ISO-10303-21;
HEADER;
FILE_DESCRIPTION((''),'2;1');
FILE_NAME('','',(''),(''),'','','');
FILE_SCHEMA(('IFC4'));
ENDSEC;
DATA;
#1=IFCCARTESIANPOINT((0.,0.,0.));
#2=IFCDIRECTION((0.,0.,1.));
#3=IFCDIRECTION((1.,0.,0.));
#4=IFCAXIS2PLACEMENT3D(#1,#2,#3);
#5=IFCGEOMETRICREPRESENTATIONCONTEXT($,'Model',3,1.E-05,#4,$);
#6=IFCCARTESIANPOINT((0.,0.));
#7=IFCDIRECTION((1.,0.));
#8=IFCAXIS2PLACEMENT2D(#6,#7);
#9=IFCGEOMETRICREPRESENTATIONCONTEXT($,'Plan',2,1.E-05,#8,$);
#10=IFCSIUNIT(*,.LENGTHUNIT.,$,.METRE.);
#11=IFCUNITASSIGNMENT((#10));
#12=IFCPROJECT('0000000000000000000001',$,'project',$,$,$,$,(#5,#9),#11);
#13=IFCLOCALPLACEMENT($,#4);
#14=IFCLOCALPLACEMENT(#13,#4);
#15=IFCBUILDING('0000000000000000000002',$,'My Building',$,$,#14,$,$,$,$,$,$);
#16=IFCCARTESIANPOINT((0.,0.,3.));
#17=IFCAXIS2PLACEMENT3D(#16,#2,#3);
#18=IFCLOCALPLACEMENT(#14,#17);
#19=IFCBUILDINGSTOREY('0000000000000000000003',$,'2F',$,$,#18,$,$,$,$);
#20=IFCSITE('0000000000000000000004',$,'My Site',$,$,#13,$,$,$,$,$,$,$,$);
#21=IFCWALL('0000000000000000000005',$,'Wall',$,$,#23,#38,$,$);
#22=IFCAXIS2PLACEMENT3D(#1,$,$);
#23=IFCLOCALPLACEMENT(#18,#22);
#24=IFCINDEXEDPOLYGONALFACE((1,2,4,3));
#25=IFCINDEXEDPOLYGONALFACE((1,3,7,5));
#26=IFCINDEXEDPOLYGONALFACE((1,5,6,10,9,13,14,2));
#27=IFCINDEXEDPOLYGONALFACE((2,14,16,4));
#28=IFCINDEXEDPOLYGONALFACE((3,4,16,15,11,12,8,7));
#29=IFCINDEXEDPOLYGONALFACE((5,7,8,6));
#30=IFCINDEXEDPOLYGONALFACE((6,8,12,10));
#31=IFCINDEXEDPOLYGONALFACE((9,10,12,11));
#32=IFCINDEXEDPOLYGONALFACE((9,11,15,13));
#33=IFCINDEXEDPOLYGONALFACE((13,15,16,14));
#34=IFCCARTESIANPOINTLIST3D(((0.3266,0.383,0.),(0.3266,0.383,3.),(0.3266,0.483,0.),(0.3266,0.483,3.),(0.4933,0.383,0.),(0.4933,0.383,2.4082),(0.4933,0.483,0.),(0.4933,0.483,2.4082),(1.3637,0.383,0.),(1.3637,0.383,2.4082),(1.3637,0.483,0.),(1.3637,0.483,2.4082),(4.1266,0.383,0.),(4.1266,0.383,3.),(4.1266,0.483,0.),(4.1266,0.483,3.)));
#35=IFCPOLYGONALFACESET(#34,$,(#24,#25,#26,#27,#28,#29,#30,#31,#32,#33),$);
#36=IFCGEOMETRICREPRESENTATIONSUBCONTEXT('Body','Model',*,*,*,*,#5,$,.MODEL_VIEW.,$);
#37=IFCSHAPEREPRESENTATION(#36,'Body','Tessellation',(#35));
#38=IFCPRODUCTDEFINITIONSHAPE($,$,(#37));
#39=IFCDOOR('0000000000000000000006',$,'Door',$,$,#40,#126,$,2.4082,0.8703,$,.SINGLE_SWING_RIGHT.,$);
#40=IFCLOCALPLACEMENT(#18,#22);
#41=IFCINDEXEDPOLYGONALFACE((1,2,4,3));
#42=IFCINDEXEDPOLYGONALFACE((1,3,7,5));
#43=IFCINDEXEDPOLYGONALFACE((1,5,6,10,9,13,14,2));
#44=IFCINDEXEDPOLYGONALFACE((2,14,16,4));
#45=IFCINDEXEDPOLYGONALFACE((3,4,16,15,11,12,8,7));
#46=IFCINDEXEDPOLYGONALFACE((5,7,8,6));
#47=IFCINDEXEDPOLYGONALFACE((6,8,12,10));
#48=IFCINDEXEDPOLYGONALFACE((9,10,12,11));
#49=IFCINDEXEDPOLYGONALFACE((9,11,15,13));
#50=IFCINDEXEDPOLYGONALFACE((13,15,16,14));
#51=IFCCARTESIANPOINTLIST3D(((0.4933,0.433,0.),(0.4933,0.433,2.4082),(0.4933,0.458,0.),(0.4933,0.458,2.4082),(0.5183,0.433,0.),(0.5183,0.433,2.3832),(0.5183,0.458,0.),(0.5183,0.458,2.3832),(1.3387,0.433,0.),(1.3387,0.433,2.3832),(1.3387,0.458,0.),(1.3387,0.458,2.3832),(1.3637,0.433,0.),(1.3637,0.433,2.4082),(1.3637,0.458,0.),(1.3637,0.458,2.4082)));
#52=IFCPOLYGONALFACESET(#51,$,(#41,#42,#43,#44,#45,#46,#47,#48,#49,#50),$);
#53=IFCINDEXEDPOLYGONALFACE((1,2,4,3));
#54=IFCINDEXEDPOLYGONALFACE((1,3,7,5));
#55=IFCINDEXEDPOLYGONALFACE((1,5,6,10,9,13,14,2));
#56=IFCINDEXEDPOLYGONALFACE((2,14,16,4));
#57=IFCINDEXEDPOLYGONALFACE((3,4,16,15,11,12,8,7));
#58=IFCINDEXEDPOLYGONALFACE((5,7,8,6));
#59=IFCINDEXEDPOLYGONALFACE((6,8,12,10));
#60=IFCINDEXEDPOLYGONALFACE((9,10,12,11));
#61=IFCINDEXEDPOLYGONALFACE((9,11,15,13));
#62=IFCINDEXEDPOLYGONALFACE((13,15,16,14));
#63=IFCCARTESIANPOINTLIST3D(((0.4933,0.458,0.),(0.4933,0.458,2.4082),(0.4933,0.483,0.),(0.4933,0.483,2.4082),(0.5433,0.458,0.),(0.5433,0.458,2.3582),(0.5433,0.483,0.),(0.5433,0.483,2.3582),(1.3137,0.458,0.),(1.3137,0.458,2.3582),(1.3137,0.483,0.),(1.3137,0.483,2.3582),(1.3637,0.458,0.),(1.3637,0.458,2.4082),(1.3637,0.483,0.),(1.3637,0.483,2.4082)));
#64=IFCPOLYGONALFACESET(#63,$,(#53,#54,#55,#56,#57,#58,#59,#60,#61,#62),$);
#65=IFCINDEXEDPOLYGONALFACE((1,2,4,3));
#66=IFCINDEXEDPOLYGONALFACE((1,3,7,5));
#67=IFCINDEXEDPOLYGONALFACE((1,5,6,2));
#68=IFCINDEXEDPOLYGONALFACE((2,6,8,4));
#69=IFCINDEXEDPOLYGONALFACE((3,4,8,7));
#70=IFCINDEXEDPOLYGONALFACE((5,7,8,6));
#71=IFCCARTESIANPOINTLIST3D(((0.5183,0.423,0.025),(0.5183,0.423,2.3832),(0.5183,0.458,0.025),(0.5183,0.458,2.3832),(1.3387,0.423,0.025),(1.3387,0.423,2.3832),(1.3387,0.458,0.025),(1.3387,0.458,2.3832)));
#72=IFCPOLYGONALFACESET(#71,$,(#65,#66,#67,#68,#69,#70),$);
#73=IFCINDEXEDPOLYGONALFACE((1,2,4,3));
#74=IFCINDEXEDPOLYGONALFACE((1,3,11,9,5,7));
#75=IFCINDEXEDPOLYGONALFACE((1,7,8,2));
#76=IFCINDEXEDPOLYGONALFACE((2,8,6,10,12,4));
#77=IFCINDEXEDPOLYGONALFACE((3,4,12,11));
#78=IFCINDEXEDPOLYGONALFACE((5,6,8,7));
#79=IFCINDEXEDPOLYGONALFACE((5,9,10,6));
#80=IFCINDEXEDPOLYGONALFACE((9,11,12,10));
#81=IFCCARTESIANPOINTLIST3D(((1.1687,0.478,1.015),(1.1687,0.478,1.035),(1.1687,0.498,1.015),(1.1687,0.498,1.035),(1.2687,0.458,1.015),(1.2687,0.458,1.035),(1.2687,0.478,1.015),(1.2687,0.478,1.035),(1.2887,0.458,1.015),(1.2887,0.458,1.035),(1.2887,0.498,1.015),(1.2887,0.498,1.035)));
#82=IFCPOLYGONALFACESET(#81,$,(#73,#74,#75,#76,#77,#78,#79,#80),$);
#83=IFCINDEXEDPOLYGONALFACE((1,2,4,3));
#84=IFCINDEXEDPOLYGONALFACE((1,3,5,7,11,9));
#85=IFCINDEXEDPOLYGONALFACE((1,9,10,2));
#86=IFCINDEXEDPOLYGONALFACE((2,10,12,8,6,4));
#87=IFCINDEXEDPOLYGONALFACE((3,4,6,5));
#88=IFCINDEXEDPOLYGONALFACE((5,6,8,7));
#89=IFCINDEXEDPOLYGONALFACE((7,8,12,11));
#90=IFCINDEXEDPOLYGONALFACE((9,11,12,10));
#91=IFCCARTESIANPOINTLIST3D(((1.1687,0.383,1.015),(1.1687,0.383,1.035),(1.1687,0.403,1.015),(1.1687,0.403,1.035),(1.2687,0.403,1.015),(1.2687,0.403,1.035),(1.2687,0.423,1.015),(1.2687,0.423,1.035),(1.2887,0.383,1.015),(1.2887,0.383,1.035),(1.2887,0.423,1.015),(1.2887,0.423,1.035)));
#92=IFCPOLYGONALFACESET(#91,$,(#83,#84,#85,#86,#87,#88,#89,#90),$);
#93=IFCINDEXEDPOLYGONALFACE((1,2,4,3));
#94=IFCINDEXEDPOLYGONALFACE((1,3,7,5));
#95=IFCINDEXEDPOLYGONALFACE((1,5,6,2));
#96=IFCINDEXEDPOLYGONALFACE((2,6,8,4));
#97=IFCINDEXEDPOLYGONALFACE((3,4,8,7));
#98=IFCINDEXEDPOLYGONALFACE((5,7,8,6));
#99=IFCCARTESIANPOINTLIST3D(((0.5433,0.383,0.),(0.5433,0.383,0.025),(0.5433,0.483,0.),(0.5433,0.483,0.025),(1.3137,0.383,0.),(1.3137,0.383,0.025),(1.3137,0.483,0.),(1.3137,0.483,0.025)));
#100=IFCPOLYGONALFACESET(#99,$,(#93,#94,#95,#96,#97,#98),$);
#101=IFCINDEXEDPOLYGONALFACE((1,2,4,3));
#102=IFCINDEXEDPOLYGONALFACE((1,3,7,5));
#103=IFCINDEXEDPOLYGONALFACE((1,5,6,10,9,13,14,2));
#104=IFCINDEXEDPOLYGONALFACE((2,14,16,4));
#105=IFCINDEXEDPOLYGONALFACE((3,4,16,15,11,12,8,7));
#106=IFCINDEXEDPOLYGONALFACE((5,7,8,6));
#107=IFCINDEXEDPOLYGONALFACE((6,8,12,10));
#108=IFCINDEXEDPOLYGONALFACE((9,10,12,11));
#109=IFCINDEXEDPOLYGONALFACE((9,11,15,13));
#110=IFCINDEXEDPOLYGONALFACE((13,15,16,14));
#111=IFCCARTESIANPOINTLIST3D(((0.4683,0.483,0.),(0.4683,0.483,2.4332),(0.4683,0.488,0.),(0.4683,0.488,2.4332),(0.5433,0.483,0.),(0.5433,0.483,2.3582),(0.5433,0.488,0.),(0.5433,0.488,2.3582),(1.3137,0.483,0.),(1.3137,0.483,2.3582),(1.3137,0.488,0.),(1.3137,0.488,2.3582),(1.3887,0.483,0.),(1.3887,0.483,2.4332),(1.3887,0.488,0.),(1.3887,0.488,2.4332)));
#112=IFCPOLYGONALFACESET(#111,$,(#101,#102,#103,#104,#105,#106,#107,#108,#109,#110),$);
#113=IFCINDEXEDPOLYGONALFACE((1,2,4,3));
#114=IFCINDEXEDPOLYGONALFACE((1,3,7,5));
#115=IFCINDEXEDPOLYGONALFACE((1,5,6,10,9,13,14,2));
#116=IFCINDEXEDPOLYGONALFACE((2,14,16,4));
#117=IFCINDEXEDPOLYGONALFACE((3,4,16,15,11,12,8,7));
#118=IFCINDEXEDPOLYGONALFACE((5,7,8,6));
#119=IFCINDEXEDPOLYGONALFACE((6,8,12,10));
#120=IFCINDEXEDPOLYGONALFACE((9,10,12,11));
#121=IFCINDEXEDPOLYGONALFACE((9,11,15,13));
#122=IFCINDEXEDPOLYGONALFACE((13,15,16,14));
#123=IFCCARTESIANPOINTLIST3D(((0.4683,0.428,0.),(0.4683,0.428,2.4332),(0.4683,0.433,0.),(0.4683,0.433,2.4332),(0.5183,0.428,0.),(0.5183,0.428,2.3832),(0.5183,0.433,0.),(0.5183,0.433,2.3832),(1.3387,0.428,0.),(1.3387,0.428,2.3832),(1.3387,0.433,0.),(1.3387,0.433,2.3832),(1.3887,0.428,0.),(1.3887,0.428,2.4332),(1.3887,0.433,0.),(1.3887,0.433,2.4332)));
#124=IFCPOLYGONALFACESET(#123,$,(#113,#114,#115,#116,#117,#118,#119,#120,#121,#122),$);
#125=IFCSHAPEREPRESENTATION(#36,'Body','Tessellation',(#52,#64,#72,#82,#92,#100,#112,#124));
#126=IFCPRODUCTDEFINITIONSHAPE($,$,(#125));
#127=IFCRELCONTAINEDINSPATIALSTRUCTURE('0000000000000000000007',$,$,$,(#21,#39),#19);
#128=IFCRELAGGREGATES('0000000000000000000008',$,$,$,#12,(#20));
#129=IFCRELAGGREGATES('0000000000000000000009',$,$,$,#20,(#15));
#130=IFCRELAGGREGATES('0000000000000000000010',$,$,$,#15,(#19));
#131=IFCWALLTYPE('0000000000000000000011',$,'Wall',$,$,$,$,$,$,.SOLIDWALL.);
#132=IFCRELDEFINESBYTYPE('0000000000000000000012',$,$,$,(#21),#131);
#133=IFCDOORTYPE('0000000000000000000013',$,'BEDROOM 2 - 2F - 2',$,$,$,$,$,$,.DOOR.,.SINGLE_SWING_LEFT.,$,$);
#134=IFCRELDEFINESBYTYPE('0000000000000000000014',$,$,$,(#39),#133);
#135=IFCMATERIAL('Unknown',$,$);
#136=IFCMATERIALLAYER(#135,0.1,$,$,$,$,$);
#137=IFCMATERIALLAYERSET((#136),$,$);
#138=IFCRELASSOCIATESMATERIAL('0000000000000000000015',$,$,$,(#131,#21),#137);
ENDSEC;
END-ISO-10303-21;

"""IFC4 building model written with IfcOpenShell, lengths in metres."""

from ifc_helpers import new_model, entity, si_unit, frame, origin_with_axes, origin_2d_with_axis, place, context, subcontext, project, spatial, line, indexed_curve, outline, extrude, shape, source, transform, mapped, material, layer, layer_set, layer_usage, type_object, type_shapes, element, fill, save


model = new_model("IFC4")

# Units and contexts
model_context = context("Model", 3, precision=1e-05, world=origin_with_axes())
plan_context = context("Plan", 2, precision=1e-05, world=origin_2d_with_axis())
body_context_1 = subcontext(model_context, "Body", "Model", "MODEL_VIEW")
body_context_2 = subcontext(plan_context, "Body", "Plan", "PLAN_VIEW")
ifc_project = project(units=[si_unit("LENGTHUNIT", "METRE")], contexts=[model_context, plan_context])

# Site, building, storey
site_placement = place(None, origin_with_axes())
site = spatial("IfcSite", under=ifc_project, at=site_placement, Name="My Site")
building_placement = place(site_placement, origin_with_axes())
building = spatial("IfcBuilding", under=site, at=building_placement, Name="My Building")
storey_placement = place(building_placement, frame((0.0, 0.0, 3.0), z_axis=(0.0, 0.0, 1.0), x_axis=(1.0, 0.0, 0.0)))
storey = spatial("IfcBuildingStorey", under=building, at=storey_placement, Name="2F")

# Shared definitions
ifc_material = material(Name="Unknown")

# Shared definitions
ifc_layer_1 = layer(ifc_material, 0.1)
ifc_layer_set_1 = layer_set([ifc_layer_1])
wall_type = type_object("IfcWallType", Name="Wall", PredefinedType="SOLIDWALL", material=ifc_layer_set_1)

# Wall, opening, door
ifc_layer_usage_1 = layer_usage(ifc_layer_set_1, "AXIS2", "POSITIVE", 0.0)
wall_1_placement = place(storey_placement, frame((0.3266, 0.383, 0.0), z_axis=(0.0, 0.0, 1.0), x_axis=(1.0, 0.0, 0.0)))
wall_1 = element("IfcWall", 1, at=wall_1_placement, inside=storey, type_object=wall_type, material=ifc_layer_usage_1, Name="Wall", context=body_context_1, shape_type="SweptSolid", body=[
    extrude(outline(indexed_curve([(0.0, 0.0), (0.0, 0.1), (3.8, 0.1), (3.8, 0.0)], segments=[line(1, 2, 3, 4, 1)])), origin_with_axes(), (0.0, 0.0, 1.0), 3.0),
])
shared_shape_1 = source(origin_with_axes(), body_context_1, "Body", "SweptSolid", [
    extrude(outline(indexed_curve([(0.0, 0.0), (0.8703, 0.0), (0.8703, 2.4082), (0.0, 2.4082)], segments=[line(1, 2, 3, 4, 1)])), frame((0.0, -0.6, 0.0), z_axis=(0.0, -1.0, 0.0), x_axis=(1.0, 0.0, 0.0)), (0.0, 0.0, -1.0), 1.2),
])
opening_1_placement = place(wall_1_placement, frame((1.0371, 0.1, 0.0), z_axis=(0.0, 0.0, 1.0), x_axis=(-1.0, 0.0, 0.0)))
opening_1 = element("IfcOpeningElement", 2, at=opening_1_placement, cuts=wall_1, PredefinedType="OPENING", context=body_context_1, shape_type="MappedRepresentation", body=[
    mapped(shared_shape_1, transform((0.0, 0.0, 0.0), x_axis=(1.0, 0.0, 0.0), y_axis=(0.0, 1.0, 0.0), z_axis=(0.0, 0.0, 1.0), scale=1.0)),
])
door_type_1 = type_object("IfcDoorType", Name="BEDROOM 2 - 2F - 2", OperationType="SINGLE_SWING_LEFT", PredefinedType="DOOR")
shared_shape_2 = source(origin_with_axes(), body_context_1, "Body", "SweptSolid", [
    extrude(outline(indexed_curve([(0.0, 0.0), (0.0, 2.4082), (0.8703, 2.4082), (0.8703, 0.0), (0.8453, 0.0), (0.8453, 2.3832), (0.025, 2.3832), (0.025, 0.0)], segments=[line(1, 2, 3, 4, 5, 6, 7, 8, 1)])), frame((0.0, 0.025, 0.0), z_axis=(0.0, -1.0, 0.0), x_axis=(1.0, 0.0, 0.0)), (0.0, 0.0, -1.0), 0.025),
    extrude(outline(indexed_curve([(0.0, 0.0), (0.0, 2.4082), (0.8703, 2.4082), (0.8703, 0.0), (0.8203, 0.0), (0.8203, 2.3582), (0.05, 2.3582), (0.05, 0.0)], segments=[line(1, 2, 3, 4, 5, 6, 7, 8, 1)])), frame((0.0, 0.0, 0.0), z_axis=(0.0, -1.0, 0.0), x_axis=(1.0, 0.0, 0.0)), (0.0, 0.0, -1.0), 0.025),
    extrude(outline(indexed_curve([(0.0, 0.0), (0.8203, 0.0), (0.8203, 0.035), (0.0, 0.035)], segments=[line(1, 2, 3, 4, 1)])), frame((0.025, 0.025, 0.025), z_axis=(0.0, 0.0, 1.0), x_axis=(1.0, 0.0, 0.0)), (0.0, 0.0, 1.0), 2.3582),
    extrude(outline(indexed_curve([(0.0, 0.0), (0.0, -0.04), (0.12, -0.04), (0.12, -0.02), (0.02, -0.02), (0.02, 0.0)], segments=[line(1, 2, 3, 4, 5, 6, 1)])), frame((0.075, 0.025, 1.015), z_axis=(0.0, 0.0, 1.0), x_axis=(1.0, 0.0, 0.0)), (0.0, 0.0, 1.0), 0.02),
    extrude(outline(indexed_curve([(0.0, 0.0), (0.0, 0.04), (0.12, 0.04), (0.12, 0.02), (0.02, 0.02), (0.02, 0.0)], segments=[line(1, 2, 3, 4, 5, 6, 1)])), frame((0.075, 0.06, 1.015), z_axis=(0.0, 0.0, 1.0), x_axis=(1.0, 0.0, 0.0)), (0.0, 0.0, 1.0), 0.02),
    extrude(outline(indexed_curve([(0.0, 0.0), (0.7703, 0.0), (0.7703, 0.1), (0.0, 0.1)], segments=[line(1, 2, 3, 4, 1)])), frame((0.05, 0.0, 0.0), z_axis=(0.0, 0.0, 1.0), x_axis=(1.0, 0.0, 0.0)), (0.0, 0.0, 1.0), 0.025),
    extrude(outline(indexed_curve([(0.0, 0.0), (0.0, 2.4332), (0.9203, 2.4332), (0.9203, 0.0), (0.8453, 0.0), (0.8453, 2.3582), (0.075, 2.3582), (0.075, 0.0)], segments=[line(1, 2, 3, 4, 5, 6, 7, 8, 1)])), frame((-0.025, -0.005, 0.0), z_axis=(0.0, -1.0, 0.0), x_axis=(1.0, 0.0, 0.0)), (0.0, 0.0, -1.0), 0.005),
    extrude(outline(indexed_curve([(0.0, 0.0), (0.0, 2.4332), (0.9203, 2.4332), (0.9203, 0.0), (0.8703, 0.0), (0.8703, 2.3832), (0.05, 2.3832), (0.05, 0.0)], segments=[line(1, 2, 3, 4, 5, 6, 7, 8, 1)])), frame((-0.025, 0.05, 0.0), z_axis=(0.0, -1.0, 0.0), x_axis=(1.0, 0.0, 0.0)), (0.0, 0.0, -1.0), 0.005),
])
shared_shape_3 = source(origin_with_axes(), body_context_2, "Body", "Curve2D", [
    entity("IfcIndexedPolyCurve", entity("IfcCartesianPointList2D", [[0.0, 0.0], [0.0, 0.05], [0.025, 0.05], [0.025, 0.025], [0.05, 0.025], [0.05, 0.0]]), [entity("IfcLineIndex", [1, 2, 3, 4, 5, 6, 1])]),
    entity("IfcIndexedPolyCurve", entity("IfcCartesianPointList2D", [[0.8703, 0.0], [0.8703, 0.05], [0.8453, 0.05], [0.8453, 0.025], [0.8203, 0.025], [0.8203, 0.0]]), [entity("IfcLineIndex", [1, 2, 3, 4, 5, 6, 1])]),
    entity("IfcTrimmedCurve", entity("IfcEllipse", entity("IfcAxis2Placement2D", entity("IfcCartesianPoint", [0.8103, 0.05]), entity("IfcDirection", [1.0, 0.0])), 0.7853, 0.8203), [entity("IfcCartesianPoint", [0.8103, 0.8703])], [entity("IfcCartesianPoint", [0.025, 0.05])], True, "CARTESIAN"),
    entity("IfcIndexedPolyCurve", entity("IfcCartesianPointList2D", [[0.8453, 0.05], [0.8103, 0.05], [0.8103, 0.8703], [0.8453, 0.8703]]), [entity("IfcLineIndex", [1, 2, 3, 4, 1])]),
])
type_shapes(door_type_1, [shared_shape_2, shared_shape_3])
door_1_placement = place(opening_1_placement, origin_with_axes())
door_1 = element("IfcDoor", 3, at=door_1_placement, inside=storey, type_object=door_type_1, Name="Door", OperationType="SINGLE_SWING_RIGHT", OverallHeight=2.4082, OverallWidth=0.8703, shapes=[
    shape(body_context_1, "Body", "MappedRepresentation", [mapped(shared_shape_2, transform((0.0, 0.0, 0.0), x_axis=(1.0, 0.0, 0.0), y_axis=(0.0, 1.0, 0.0), z_axis=(0.0, 0.0, 1.0), scale=1.0))]),
    shape(body_context_2, "Body", "MappedRepresentation", [mapped(shared_shape_3, transform((0.0, 0.0, 0.0), x_axis=(1.0, 0.0, 0.0), y_axis=(0.0, 1.0, 0.0), z_axis=(0.0, 0.0, 1.0), scale=1.0))]),
])
fill(opening_1, door_1)

save(model, "model.ifc")
